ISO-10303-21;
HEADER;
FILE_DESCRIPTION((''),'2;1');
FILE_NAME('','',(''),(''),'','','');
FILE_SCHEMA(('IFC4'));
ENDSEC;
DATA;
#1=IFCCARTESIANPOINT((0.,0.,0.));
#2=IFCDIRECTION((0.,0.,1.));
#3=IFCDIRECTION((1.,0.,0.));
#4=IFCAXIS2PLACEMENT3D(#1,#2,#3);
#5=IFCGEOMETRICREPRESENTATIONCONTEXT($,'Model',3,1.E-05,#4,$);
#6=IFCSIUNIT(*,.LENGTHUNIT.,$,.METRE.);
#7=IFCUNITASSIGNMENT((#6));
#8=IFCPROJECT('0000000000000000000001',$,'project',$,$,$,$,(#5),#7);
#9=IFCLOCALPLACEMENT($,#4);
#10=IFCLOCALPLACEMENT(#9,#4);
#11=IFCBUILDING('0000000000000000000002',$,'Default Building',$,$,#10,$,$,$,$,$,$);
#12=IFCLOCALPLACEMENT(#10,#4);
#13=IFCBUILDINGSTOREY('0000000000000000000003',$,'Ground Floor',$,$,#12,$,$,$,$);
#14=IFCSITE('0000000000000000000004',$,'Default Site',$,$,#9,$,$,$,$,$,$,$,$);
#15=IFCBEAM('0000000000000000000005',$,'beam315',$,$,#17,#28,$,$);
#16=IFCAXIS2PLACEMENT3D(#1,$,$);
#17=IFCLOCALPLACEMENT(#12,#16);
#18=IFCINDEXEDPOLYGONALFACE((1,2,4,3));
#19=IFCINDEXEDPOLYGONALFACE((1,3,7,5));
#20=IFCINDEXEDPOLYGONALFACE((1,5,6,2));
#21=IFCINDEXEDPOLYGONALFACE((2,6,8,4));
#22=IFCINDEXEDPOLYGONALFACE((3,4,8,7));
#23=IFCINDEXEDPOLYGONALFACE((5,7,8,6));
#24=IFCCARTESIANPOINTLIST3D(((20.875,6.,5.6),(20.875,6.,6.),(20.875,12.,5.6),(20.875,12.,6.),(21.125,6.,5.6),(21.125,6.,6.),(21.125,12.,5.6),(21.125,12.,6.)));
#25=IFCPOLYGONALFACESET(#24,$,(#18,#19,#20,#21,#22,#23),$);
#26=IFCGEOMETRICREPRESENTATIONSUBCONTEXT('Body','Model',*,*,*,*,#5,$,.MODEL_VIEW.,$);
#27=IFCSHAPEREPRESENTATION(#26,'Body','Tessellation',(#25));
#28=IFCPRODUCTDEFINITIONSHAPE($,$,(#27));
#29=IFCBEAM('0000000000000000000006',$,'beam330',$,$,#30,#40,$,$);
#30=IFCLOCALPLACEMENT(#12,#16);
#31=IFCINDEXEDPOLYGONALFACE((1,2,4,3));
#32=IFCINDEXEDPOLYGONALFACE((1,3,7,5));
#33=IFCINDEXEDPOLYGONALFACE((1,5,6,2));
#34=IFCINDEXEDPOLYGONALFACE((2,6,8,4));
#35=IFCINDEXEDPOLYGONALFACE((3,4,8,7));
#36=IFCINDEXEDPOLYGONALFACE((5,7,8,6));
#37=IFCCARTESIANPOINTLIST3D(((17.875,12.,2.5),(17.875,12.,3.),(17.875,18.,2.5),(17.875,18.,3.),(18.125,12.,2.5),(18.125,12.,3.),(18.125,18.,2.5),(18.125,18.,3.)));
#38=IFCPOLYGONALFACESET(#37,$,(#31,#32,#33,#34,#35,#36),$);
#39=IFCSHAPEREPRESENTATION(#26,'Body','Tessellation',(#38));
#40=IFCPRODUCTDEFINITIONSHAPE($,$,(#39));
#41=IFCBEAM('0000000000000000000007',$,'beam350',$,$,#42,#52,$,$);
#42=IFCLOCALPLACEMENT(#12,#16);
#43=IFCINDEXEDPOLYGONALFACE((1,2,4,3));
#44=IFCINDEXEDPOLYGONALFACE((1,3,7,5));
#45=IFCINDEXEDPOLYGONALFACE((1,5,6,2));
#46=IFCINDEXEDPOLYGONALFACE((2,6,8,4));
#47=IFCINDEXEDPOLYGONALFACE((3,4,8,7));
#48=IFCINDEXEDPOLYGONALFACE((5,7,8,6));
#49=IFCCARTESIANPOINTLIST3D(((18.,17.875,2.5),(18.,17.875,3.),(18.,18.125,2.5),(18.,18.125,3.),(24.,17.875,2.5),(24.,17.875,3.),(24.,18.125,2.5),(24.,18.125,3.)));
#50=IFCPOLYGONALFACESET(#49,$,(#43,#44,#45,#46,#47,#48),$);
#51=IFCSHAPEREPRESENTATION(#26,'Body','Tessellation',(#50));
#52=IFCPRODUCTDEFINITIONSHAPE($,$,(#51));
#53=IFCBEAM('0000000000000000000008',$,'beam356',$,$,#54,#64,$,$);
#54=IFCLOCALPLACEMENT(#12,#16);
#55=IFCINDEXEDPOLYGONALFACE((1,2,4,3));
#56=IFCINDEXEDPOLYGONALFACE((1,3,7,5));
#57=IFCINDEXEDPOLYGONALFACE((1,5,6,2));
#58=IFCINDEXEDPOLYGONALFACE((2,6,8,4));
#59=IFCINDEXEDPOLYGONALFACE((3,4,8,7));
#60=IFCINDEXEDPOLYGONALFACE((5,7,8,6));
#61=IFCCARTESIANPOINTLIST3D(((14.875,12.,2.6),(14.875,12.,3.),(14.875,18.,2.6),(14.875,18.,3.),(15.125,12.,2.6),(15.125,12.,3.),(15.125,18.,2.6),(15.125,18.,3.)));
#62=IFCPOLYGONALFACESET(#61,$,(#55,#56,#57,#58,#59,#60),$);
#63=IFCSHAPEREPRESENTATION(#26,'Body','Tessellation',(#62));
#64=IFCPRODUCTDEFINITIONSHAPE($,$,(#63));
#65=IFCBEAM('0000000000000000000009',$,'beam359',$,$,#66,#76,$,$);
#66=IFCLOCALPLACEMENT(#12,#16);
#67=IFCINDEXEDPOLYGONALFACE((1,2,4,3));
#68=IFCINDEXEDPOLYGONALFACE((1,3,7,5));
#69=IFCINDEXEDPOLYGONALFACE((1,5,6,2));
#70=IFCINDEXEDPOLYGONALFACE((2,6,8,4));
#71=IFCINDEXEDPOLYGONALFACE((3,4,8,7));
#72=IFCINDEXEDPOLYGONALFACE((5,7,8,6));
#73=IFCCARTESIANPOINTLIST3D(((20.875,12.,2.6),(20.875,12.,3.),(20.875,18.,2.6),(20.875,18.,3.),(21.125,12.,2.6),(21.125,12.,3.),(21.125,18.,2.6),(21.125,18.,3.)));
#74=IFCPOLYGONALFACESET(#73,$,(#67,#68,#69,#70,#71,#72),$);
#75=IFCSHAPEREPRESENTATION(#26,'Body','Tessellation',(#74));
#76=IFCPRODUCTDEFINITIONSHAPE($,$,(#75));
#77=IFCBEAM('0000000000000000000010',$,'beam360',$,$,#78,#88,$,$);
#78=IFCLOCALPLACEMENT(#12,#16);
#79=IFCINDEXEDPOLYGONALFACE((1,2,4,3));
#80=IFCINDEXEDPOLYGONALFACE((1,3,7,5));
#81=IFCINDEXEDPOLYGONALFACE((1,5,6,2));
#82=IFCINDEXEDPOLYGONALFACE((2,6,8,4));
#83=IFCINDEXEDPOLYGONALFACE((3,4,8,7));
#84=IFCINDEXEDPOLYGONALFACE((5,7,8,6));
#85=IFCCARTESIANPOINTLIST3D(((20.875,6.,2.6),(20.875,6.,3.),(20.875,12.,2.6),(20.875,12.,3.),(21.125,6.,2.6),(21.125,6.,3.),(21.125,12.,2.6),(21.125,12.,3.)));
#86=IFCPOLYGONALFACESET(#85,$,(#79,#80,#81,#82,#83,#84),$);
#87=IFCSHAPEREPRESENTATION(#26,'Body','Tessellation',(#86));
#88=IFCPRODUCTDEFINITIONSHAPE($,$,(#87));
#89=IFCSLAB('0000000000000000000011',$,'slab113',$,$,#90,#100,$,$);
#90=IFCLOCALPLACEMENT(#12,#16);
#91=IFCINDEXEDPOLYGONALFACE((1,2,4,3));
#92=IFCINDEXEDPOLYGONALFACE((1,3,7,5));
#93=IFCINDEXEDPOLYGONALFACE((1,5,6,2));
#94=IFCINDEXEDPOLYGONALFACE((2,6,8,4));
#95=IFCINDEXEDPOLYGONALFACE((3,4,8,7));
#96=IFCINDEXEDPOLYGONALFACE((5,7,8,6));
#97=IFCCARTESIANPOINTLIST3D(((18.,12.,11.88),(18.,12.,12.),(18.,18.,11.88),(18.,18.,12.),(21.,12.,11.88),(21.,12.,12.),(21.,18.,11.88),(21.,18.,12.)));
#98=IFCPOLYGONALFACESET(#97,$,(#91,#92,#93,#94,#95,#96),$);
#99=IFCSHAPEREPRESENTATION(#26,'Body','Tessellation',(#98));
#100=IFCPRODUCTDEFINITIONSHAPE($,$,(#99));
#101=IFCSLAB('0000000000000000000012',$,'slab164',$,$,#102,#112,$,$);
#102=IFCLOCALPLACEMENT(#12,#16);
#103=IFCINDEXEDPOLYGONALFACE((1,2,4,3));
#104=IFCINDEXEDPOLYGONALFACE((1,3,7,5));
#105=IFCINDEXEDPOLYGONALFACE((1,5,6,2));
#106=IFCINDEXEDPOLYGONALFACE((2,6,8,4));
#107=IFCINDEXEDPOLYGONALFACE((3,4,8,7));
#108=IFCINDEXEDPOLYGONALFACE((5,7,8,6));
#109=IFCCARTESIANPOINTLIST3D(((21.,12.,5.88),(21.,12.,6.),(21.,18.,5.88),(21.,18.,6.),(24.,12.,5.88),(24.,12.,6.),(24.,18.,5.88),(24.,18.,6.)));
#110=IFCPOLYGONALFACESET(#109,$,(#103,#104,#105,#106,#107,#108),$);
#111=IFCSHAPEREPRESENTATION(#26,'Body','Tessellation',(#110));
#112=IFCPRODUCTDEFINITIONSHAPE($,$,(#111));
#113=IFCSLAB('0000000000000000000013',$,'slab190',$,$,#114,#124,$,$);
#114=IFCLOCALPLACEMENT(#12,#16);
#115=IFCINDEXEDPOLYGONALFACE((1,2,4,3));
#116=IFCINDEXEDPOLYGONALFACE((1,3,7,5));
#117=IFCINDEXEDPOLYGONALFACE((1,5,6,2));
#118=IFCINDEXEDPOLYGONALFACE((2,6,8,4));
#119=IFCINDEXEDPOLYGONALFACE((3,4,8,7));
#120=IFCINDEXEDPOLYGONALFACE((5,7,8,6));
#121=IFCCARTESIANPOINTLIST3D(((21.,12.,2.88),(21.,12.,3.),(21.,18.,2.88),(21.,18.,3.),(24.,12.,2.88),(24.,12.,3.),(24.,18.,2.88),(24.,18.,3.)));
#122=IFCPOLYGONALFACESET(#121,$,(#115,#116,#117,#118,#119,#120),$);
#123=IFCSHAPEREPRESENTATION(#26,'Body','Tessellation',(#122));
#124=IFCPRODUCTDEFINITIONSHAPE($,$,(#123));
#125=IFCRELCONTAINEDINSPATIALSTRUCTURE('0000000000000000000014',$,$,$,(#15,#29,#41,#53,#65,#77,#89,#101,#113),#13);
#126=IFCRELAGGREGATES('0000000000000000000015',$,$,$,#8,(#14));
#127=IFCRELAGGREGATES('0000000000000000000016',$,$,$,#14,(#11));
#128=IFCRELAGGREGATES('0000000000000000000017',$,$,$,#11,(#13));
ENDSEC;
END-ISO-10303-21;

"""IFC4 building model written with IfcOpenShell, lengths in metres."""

from ifc_helpers import new_model, si_unit, frame, origin_with_axes, place, context, subcontext, project, spatial, indexed_curve, outline, extrude, element, save


model = new_model("IFC4")

# Units and contexts
model_context = context("Model", 3, precision=1e-05, world=origin_with_axes())
body_context = subcontext(model_context, "Body", "Model", "MODEL_VIEW")
ifc_project = project(units=[si_unit("LENGTHUNIT", "METRE")], contexts=[model_context])

# Site, building, storey
site_placement = place(None, origin_with_axes())
site = spatial("IfcSite", under=ifc_project, at=site_placement, Name="Default Site")
building_placement = place(site_placement, origin_with_axes())
building = spatial("IfcBuilding", under=site, at=building_placement, Name="Default Building")
storey_placement = place(building_placement, origin_with_axes())
storey = spatial("IfcBuildingStorey", under=building, at=storey_placement, Name="Ground Floor")

# Beams
for number, where, z_axis, x_axis, name in (
    (1, (20.875, 12.0, 5.6), (0.0, 0.0, 1.0), (0.0, -1.0, 0.0), "beam315"),
):
    element("IfcBeam", number, at=place(storey_placement, frame(where, z_axis=z_axis, x_axis=x_axis)), inside=storey, Name=name, context=body_context, shape_type="SweptSolid", body=[
        extrude(outline(indexed_curve([(0.0, 0.0), (0.0, 0.25), (6.0, 0.25), (6.0, 0.0), (0.0, 0.0)], self_intersect=False)), origin_with_axes(), (0.0, 0.0, 1.0), 0.4),
    ])
for number, where, z_axis, x_axis, name in (
    (2, (18.125, 12.0, 2.5), (0.0, 0.0, 1.0), (0.0, 1.0, 0.0), "beam330"),
    (3, (18.0, 17.875, 2.5), (0.0, 0.0, 1.0), (1.0, 0.0, 0.0), "beam350"),
):
    element("IfcBeam", number, at=place(storey_placement, frame(where, z_axis=z_axis, x_axis=x_axis)), inside=storey, Name=name, context=body_context, shape_type="SweptSolid", body=[
        extrude(outline(indexed_curve([(0.0, 0.0), (0.0, 0.25), (6.0, 0.25), (6.0, 0.0), (0.0, 0.0)], self_intersect=False)), origin_with_axes(), (0.0, 0.0, 1.0), 0.5),
    ])
for number, where, z_axis, x_axis, name in (
    (4, (14.875, 18.0, 2.6), (0.0, 0.0, 1.0), (0.0, -1.0, 0.0), "beam356"),
    (5, (20.875, 18.0, 2.6), (0.0, 0.0, 1.0), (0.0, -1.0, 0.0), "beam359"),
    (6, (20.875, 12.0, 2.6), (0.0, 0.0, 1.0), (0.0, -1.0, 0.0), "beam360"),
):
    element("IfcBeam", number, at=place(storey_placement, frame(where, z_axis=z_axis, x_axis=x_axis)), inside=storey, Name=name, context=body_context, shape_type="SweptSolid", body=[
        extrude(outline(indexed_curve([(0.0, 0.0), (0.0, 0.25), (6.0, 0.25), (6.0, 0.0), (0.0, 0.0)], self_intersect=False)), origin_with_axes(), (0.0, 0.0, 1.0), 0.4),
    ])

# Slabs
for number, where, z_axis, x_axis, name in (
    (7, (18.0, 12.0, 11.88), (0.0, 0.0, 1.0), (1.0, 0.0, 0.0), "slab113"),
    (8, (21.0, 12.0, 5.88), (0.0, 0.0, 1.0), (1.0, 0.0, 0.0), "slab164"),
    (9, (21.0, 12.0, 2.88), (0.0, 0.0, 1.0), (1.0, 0.0, 0.0), "slab190"),
):
    element("IfcSlab", number, at=place(storey_placement, frame(where, z_axis=z_axis, x_axis=x_axis)), inside=storey, Name=name, context=body_context, shape_type="SweptSolid", body=[
        extrude(outline(indexed_curve([(0.0, 0.0), (0.0, 6.0), (3.0, 6.0), (3.0, 0.0), (0.0, 0.0)], self_intersect=False)), origin_with_axes(), (0.0, 0.0, 1.0), 0.12),
    ])

save(model, "model.ifc")
